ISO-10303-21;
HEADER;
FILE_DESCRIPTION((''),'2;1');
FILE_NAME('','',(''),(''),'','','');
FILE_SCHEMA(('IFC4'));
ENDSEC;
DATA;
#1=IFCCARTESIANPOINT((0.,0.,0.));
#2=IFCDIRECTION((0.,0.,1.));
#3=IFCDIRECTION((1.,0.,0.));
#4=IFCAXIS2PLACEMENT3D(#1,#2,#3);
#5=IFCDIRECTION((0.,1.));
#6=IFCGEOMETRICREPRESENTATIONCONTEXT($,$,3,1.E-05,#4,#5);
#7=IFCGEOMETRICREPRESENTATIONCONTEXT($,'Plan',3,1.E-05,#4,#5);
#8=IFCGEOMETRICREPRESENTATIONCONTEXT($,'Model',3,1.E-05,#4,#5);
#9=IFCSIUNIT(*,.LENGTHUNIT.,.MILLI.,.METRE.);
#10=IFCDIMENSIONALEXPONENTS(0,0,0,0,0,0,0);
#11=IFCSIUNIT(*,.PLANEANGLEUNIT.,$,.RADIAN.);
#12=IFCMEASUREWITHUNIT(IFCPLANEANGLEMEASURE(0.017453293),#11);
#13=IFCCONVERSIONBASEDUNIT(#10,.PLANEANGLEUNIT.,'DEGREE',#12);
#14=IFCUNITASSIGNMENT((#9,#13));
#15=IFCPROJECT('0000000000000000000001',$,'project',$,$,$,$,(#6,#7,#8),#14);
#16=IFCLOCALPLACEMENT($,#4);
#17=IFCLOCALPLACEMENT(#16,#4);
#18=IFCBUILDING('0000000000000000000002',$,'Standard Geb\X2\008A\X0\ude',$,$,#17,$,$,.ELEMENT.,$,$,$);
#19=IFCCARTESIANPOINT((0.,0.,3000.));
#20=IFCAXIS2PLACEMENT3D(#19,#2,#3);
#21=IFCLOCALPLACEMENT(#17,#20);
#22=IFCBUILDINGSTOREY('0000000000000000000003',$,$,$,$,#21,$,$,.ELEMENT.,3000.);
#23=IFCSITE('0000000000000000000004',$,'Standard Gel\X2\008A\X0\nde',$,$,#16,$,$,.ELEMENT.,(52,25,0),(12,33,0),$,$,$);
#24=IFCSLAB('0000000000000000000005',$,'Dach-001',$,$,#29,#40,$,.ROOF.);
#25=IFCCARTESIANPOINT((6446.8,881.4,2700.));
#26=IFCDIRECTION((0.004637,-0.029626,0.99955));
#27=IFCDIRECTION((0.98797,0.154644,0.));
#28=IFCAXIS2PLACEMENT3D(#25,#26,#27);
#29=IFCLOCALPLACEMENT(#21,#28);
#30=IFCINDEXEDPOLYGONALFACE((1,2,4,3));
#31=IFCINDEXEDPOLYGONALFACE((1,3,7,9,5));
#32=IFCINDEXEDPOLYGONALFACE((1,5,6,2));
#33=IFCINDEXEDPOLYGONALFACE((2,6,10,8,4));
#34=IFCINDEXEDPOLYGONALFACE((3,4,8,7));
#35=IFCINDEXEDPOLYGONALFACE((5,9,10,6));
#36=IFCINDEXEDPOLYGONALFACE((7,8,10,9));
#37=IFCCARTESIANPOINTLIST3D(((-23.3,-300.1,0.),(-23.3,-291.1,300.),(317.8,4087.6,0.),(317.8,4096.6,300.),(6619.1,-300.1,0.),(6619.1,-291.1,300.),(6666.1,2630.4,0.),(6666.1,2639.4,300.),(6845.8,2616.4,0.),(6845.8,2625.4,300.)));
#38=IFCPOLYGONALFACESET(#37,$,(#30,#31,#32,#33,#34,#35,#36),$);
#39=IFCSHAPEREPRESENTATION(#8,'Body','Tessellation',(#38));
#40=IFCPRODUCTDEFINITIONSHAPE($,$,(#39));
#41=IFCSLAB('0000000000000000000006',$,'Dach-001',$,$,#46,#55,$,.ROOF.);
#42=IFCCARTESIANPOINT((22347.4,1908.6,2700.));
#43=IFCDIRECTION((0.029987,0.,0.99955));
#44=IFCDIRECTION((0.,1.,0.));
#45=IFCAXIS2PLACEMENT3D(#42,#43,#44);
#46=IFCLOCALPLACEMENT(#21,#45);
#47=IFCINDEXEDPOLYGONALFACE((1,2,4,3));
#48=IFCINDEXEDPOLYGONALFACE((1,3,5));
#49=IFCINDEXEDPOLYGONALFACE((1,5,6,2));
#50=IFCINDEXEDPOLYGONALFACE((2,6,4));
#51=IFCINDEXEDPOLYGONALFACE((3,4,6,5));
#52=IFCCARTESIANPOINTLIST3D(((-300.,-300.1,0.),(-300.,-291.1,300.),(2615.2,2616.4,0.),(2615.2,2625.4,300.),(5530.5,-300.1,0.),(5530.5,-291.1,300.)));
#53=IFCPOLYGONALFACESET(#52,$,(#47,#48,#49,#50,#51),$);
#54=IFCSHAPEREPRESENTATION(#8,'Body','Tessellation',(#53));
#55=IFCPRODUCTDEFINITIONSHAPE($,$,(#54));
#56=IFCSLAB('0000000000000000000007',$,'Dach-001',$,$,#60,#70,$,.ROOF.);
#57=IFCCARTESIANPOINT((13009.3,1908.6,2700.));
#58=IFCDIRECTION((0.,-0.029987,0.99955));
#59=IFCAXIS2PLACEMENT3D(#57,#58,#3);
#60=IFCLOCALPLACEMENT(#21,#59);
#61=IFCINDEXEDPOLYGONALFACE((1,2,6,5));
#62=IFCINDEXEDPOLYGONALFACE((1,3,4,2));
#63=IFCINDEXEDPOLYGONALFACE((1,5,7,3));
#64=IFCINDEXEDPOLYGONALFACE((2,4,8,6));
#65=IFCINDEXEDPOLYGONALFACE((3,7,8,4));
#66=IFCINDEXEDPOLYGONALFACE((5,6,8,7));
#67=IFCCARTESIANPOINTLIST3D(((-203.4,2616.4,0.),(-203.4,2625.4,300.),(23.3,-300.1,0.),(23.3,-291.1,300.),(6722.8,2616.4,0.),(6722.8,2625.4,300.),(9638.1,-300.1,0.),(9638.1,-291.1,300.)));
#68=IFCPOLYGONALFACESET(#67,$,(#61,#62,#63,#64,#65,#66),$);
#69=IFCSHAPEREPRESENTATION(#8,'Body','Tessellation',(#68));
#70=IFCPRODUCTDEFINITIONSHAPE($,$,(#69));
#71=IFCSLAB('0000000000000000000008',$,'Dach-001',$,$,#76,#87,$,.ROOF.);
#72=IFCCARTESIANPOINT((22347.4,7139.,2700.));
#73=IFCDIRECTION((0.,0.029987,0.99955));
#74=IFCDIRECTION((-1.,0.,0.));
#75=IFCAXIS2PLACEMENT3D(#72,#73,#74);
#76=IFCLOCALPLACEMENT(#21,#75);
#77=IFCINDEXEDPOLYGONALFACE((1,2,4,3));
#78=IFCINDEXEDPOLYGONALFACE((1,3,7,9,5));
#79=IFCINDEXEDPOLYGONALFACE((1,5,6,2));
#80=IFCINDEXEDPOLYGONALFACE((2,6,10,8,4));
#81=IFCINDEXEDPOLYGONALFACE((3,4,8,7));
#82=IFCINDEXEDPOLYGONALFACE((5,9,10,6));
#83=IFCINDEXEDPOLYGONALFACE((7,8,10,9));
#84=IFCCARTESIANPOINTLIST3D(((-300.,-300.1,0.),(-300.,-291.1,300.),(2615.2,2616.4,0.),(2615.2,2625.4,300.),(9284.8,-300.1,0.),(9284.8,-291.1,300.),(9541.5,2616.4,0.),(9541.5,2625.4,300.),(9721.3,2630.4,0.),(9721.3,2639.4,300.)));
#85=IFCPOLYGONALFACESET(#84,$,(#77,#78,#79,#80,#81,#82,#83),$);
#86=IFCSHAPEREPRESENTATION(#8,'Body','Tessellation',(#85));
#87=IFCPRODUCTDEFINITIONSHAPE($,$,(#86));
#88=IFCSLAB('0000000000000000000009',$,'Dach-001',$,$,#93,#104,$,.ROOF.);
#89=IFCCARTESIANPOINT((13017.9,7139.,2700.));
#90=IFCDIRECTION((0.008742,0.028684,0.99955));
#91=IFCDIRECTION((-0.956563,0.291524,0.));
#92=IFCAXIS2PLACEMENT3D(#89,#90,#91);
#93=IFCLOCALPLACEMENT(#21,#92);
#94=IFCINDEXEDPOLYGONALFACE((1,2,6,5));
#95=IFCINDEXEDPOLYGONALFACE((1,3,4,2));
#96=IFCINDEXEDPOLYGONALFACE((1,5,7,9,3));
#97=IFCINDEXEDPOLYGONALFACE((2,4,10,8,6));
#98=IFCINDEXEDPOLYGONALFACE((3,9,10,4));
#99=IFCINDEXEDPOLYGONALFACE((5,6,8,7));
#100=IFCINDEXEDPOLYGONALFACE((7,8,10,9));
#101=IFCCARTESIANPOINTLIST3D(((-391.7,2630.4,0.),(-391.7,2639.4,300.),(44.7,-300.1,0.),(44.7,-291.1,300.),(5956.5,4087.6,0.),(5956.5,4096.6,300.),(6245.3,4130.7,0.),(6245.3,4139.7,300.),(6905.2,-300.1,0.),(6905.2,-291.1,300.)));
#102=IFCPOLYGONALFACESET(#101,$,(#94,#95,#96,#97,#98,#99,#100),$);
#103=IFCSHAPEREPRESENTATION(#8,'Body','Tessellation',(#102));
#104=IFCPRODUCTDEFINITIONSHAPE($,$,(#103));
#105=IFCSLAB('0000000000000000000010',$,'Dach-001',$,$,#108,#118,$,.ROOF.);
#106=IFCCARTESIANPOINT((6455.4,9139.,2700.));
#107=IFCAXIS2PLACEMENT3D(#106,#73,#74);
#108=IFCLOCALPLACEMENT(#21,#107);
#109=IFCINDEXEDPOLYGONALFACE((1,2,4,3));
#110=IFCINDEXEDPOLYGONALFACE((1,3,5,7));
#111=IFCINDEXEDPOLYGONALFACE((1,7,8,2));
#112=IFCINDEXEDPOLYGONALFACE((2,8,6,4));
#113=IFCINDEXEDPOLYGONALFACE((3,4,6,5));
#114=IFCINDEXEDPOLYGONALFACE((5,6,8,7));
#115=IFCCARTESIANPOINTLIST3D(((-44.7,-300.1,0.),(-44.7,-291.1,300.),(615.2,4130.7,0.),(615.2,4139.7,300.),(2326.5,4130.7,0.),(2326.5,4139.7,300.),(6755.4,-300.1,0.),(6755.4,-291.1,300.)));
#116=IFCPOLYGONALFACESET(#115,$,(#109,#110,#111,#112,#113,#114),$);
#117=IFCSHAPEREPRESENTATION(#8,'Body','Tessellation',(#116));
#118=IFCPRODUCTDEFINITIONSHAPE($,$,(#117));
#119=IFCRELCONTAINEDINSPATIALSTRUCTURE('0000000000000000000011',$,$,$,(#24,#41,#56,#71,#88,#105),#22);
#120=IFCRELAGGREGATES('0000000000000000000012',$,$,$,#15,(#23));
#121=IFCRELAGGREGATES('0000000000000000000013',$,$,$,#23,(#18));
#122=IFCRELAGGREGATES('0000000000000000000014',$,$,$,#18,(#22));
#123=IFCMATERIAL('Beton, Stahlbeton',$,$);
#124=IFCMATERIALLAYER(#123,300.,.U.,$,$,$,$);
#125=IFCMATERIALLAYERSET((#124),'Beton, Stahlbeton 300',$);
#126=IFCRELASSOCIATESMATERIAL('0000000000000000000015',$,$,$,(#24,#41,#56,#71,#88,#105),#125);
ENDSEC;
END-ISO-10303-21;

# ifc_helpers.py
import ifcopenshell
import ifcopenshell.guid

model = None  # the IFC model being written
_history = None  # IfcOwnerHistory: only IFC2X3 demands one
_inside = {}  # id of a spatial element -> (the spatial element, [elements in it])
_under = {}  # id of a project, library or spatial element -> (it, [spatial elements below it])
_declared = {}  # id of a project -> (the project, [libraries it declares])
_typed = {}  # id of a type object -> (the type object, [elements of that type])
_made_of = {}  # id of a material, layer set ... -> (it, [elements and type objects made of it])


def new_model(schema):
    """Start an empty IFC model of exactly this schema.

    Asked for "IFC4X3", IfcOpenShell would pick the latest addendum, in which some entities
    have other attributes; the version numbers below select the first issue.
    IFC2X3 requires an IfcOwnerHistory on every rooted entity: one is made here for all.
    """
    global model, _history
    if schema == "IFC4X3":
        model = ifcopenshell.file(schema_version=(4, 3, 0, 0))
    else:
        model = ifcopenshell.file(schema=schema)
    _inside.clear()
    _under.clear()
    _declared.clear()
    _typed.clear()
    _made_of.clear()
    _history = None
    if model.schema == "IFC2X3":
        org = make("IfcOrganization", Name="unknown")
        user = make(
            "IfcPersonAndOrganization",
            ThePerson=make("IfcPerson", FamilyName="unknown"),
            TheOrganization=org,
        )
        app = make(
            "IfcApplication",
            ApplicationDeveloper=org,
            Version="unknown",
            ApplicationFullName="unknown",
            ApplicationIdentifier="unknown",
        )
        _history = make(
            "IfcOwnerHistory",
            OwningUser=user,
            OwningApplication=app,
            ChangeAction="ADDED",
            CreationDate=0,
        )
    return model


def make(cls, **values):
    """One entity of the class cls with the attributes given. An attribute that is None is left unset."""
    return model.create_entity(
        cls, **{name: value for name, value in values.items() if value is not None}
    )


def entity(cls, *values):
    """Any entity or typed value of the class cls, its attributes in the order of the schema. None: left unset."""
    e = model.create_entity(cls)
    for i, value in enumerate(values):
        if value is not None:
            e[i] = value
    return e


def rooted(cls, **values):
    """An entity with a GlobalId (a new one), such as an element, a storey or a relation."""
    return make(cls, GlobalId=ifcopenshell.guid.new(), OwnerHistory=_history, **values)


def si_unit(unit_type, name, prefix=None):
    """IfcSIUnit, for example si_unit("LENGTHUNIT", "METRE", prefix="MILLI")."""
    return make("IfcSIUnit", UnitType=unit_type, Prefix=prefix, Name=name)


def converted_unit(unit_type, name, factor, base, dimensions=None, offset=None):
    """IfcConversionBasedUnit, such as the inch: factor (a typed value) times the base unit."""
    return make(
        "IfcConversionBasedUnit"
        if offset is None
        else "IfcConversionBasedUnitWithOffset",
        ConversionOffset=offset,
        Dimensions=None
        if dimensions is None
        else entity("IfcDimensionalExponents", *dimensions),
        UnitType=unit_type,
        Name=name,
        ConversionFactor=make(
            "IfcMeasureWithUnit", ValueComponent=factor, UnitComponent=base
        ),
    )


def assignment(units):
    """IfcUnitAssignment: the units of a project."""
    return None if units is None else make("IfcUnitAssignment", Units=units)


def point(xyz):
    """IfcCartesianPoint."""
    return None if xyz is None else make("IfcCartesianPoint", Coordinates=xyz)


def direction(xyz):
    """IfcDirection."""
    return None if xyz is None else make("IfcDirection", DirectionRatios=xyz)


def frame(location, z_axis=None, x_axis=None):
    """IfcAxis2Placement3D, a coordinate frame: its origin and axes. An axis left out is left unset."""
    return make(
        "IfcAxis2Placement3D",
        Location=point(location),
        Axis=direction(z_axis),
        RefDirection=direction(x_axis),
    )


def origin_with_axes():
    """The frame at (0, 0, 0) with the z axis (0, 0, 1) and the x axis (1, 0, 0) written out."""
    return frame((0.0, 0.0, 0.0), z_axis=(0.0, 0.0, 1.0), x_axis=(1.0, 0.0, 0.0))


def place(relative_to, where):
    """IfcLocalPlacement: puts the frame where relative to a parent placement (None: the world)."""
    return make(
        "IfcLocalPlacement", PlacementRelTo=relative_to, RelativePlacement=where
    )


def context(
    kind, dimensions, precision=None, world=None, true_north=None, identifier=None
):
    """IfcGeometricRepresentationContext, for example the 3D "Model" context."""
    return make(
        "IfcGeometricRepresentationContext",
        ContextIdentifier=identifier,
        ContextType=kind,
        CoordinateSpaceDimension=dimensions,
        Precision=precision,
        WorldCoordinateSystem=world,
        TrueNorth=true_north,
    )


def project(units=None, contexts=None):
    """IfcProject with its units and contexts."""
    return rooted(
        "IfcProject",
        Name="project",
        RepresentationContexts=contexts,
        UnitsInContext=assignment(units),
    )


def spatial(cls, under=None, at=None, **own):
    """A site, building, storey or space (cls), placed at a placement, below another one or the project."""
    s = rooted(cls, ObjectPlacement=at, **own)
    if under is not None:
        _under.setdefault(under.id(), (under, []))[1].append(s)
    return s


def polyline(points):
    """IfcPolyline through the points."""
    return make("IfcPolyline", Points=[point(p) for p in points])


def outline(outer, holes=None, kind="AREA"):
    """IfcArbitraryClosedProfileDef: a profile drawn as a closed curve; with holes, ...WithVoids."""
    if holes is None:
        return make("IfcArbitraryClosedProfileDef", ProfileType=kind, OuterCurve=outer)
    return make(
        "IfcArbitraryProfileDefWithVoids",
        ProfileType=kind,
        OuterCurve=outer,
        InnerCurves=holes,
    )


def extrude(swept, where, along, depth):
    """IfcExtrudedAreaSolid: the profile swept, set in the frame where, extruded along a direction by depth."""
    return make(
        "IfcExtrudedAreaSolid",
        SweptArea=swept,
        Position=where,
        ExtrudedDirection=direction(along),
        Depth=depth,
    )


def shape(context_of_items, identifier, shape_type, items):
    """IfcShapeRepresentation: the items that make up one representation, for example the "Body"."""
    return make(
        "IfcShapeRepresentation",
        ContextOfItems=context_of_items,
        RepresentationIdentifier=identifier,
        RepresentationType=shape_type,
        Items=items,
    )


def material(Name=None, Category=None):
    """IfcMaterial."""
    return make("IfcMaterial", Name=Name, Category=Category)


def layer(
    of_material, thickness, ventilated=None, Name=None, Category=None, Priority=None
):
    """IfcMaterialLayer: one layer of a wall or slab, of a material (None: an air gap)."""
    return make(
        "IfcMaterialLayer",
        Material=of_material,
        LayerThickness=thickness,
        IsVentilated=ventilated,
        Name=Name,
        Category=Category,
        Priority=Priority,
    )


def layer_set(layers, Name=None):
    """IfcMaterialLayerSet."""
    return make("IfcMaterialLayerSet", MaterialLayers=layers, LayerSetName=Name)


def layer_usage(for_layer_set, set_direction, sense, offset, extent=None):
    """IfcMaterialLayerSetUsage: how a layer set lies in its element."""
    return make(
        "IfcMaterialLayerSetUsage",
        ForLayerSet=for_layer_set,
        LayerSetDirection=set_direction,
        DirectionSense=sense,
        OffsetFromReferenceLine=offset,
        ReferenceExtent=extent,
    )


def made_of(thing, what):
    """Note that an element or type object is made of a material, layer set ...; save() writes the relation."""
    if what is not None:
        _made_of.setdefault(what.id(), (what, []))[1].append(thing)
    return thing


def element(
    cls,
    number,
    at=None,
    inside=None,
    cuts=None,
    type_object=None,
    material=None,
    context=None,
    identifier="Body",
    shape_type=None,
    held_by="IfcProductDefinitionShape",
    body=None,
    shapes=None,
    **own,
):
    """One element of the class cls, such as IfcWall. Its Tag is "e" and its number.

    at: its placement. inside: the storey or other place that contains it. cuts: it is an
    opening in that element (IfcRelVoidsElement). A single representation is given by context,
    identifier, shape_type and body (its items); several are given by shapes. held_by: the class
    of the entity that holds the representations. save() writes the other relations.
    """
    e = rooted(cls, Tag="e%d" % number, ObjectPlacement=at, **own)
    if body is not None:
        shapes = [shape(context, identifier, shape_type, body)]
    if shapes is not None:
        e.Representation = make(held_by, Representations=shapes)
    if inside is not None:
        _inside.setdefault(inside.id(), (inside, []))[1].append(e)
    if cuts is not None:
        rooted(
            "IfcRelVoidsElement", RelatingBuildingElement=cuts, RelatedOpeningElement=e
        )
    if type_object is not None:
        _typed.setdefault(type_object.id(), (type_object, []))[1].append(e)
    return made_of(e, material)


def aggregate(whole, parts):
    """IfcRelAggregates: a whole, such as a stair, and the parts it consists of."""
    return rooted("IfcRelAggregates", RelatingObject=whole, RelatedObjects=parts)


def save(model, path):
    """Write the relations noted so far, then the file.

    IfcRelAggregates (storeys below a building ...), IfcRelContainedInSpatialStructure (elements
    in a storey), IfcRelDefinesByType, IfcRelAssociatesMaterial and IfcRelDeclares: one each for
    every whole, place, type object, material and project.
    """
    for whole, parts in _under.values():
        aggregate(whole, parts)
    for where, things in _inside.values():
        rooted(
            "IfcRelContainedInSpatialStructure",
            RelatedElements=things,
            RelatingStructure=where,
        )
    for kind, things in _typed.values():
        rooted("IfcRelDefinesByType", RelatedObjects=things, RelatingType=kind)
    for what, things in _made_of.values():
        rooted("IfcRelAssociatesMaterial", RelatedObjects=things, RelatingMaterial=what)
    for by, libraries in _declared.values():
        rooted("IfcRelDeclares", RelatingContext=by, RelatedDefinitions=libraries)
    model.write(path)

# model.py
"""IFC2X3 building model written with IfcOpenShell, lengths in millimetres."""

from ifc_helpers import new_model, entity, si_unit, converted_unit, direction, frame, origin_with_axes, place, context, project, spatial, polyline, outline, extrude, material, layer, layer_set, layer_usage, element, save


model = new_model("IFC2X3")

# Units and contexts
model_context = context("Model", 3, precision=1e-05, world=origin_with_axes(), true_north=direction((0.0, 1.0)))
context_of_model = context(None, 3, precision=1e-05, world=origin_with_axes(), true_north=direction((0.0, 1.0)))
plan_context = context("Plan", 3, precision=1e-05, world=origin_with_axes(), true_north=direction((0.0, 1.0)))
ifc_project = project(units=[si_unit("LENGTHUNIT", "METRE", prefix="MILLI"), converted_unit("PLANEANGLEUNIT", "DEGREE", entity("IfcPlaneAngleMeasure", 0.017453293), si_unit("PLANEANGLEUNIT", "RADIAN"), dimensions=[0, 0, 0, 0, 0, 0, 0])], contexts=[context_of_model, plan_context, model_context])

# Site, building, storey
site_placement = place(None, origin_with_axes())
site = spatial("IfcSite", under=ifc_project, at=site_placement, Name="Standard Gel\u008ande", CompositionType="ELEMENT", RefLatitude=(52, 25, 0), RefLongitude=(12, 33, 0))
building_placement = place(site_placement, origin_with_axes())
building = spatial("IfcBuilding", under=site, at=building_placement, Name="Standard Geb\u008aude", CompositionType="ELEMENT")
storey_placement = place(building_placement, frame((0.0, 0.0, 3000.0), z_axis=(0.0, 0.0, 1.0), x_axis=(1.0, 0.0, 0.0)))
storey = spatial("IfcBuildingStorey", under=building, at=storey_placement, CompositionType="ELEMENT", Elevation=3000.0)

# Slabs
ifc_material_1 = material(Name="Beton, Stahlbeton")
ifc_layer_1 = layer(ifc_material_1, 300.0, ventilated="UNKNOWN")
ifc_layer_set_1 = layer_set([ifc_layer_1], Name="Beton, Stahlbeton 300")
ifc_layer_usage_1 = layer_usage(ifc_layer_set_1, "AXIS3", "NEGATIVE", 300.0)
slab_1_placement = place(storey_placement, frame((6446.8, 881.4, 2700.0), z_axis=(0.004637, -0.029626, 0.99955), x_axis=(0.98797, 0.154644, 0.0)))
element("IfcSlab", 1, at=slab_1_placement, inside=storey, material=ifc_layer_usage_1, Name="Dach-001", PredefinedType="ROOF", context=model_context, shape_type="SweptSolid", body=[
    extrude(outline(polyline([(-23.3, -300.1), (6619.1, -300.1), (6845.8, 2616.4), (6666.1, 2630.4), (317.8, 4087.6), (-23.3, -300.1)])), origin_with_axes(), (0.0, 0.029987, 0.99955), 300.1),
])
ifc_layer_usage_2 = layer_usage(ifc_layer_set_1, "AXIS3", "NEGATIVE", 300.0)
slab_2_placement = place(storey_placement, frame((22347.4, 1908.6, 2700.0), z_axis=(0.029987, 0.0, 0.99955), x_axis=(0.0, 1.0, 0.0)))
element("IfcSlab", 2, at=slab_2_placement, inside=storey, material=ifc_layer_usage_2, Name="Dach-001", PredefinedType="ROOF", context=model_context, shape_type="SweptSolid", body=[
    extrude(outline(polyline([(-300.0, -300.1), (5530.5, -300.1), (2615.2, 2616.4), (-300.0, -300.1)])), origin_with_axes(), (0.0, 0.029987, 0.99955), 300.1),
])
ifc_layer_usage_3 = layer_usage(ifc_layer_set_1, "AXIS3", "NEGATIVE", 300.0)
slab_3_placement = place(storey_placement, frame((13009.3, 1908.6, 2700.0), z_axis=(0.0, -0.029987, 0.99955), x_axis=(1.0, 0.0, 0.0)))
element("IfcSlab", 3, at=slab_3_placement, inside=storey, material=ifc_layer_usage_3, Name="Dach-001", PredefinedType="ROOF", context=model_context, shape_type="SweptSolid", body=[
    extrude(outline(polyline([(23.3, -300.1), (9638.1, -300.1), (6722.8, 2616.4), (-203.4, 2616.4), (23.3, -300.1)])), origin_with_axes(), (0.0, 0.029987, 0.99955), 300.1),
])
ifc_layer_usage_4 = layer_usage(ifc_layer_set_1, "AXIS3", "NEGATIVE", 300.0)
slab_4_placement = place(storey_placement, frame((22347.4, 7139.0, 2700.0), z_axis=(0.0, 0.029987, 0.99955), x_axis=(-1.0, 0.0, 0.0)))
element("IfcSlab", 4, at=slab_4_placement, inside=storey, material=ifc_layer_usage_4, Name="Dach-001", PredefinedType="ROOF", context=model_context, shape_type="SweptSolid", body=[
    extrude(outline(polyline([(-300.0, -300.1), (9284.8, -300.1), (9721.3, 2630.4), (9541.5, 2616.4), (2615.2, 2616.4), (-300.0, -300.1)])), origin_with_axes(), (0.0, 0.029987, 0.99955), 300.1),
])
ifc_layer_usage_5 = layer_usage(ifc_layer_set_1, "AXIS3", "NEGATIVE", 300.0)
slab_5_placement = place(storey_placement, frame((13017.9, 7139.0, 2700.0), z_axis=(0.008742, 0.028684, 0.99955), x_axis=(-0.956563, 0.291524, 0.0)))
element("IfcSlab", 5, at=slab_5_placement, inside=storey, material=ifc_layer_usage_5, Name="Dach-001", PredefinedType="ROOF", context=model_context, shape_type="SweptSolid", body=[
    extrude(outline(polyline([(44.7, -300.1), (6905.2, -300.1), (6245.3, 4130.7), (5956.5, 4087.6), (-391.7, 2630.4), (44.7, -300.1)])), origin_with_axes(), (0.0, 0.029987, 0.99955), 300.1),
])
ifc_layer_usage_6 = layer_usage(ifc_layer_set_1, "AXIS3", "NEGATIVE", 300.0)
slab_6_placement = place(storey_placement, frame((6455.4, 9139.0, 2700.0), z_axis=(0.0, 0.029987, 0.99955), x_axis=(-1.0, 0.0, 0.0)))
element("IfcSlab", 6, at=slab_6_placement, inside=storey, material=ifc_layer_usage_6, Name="Dach-001", PredefinedType="ROOF", context=model_context, shape_type="SweptSolid", body=[
    extrude(outline(polyline([(-44.7, -300.1), (6755.4, -300.1), (2326.5, 4130.7), (615.2, 4130.7), (-44.7, -300.1)])), origin_with_axes(), (0.0, 0.029987, 0.99955), 300.1),
])

save(model, "model.ifc")
